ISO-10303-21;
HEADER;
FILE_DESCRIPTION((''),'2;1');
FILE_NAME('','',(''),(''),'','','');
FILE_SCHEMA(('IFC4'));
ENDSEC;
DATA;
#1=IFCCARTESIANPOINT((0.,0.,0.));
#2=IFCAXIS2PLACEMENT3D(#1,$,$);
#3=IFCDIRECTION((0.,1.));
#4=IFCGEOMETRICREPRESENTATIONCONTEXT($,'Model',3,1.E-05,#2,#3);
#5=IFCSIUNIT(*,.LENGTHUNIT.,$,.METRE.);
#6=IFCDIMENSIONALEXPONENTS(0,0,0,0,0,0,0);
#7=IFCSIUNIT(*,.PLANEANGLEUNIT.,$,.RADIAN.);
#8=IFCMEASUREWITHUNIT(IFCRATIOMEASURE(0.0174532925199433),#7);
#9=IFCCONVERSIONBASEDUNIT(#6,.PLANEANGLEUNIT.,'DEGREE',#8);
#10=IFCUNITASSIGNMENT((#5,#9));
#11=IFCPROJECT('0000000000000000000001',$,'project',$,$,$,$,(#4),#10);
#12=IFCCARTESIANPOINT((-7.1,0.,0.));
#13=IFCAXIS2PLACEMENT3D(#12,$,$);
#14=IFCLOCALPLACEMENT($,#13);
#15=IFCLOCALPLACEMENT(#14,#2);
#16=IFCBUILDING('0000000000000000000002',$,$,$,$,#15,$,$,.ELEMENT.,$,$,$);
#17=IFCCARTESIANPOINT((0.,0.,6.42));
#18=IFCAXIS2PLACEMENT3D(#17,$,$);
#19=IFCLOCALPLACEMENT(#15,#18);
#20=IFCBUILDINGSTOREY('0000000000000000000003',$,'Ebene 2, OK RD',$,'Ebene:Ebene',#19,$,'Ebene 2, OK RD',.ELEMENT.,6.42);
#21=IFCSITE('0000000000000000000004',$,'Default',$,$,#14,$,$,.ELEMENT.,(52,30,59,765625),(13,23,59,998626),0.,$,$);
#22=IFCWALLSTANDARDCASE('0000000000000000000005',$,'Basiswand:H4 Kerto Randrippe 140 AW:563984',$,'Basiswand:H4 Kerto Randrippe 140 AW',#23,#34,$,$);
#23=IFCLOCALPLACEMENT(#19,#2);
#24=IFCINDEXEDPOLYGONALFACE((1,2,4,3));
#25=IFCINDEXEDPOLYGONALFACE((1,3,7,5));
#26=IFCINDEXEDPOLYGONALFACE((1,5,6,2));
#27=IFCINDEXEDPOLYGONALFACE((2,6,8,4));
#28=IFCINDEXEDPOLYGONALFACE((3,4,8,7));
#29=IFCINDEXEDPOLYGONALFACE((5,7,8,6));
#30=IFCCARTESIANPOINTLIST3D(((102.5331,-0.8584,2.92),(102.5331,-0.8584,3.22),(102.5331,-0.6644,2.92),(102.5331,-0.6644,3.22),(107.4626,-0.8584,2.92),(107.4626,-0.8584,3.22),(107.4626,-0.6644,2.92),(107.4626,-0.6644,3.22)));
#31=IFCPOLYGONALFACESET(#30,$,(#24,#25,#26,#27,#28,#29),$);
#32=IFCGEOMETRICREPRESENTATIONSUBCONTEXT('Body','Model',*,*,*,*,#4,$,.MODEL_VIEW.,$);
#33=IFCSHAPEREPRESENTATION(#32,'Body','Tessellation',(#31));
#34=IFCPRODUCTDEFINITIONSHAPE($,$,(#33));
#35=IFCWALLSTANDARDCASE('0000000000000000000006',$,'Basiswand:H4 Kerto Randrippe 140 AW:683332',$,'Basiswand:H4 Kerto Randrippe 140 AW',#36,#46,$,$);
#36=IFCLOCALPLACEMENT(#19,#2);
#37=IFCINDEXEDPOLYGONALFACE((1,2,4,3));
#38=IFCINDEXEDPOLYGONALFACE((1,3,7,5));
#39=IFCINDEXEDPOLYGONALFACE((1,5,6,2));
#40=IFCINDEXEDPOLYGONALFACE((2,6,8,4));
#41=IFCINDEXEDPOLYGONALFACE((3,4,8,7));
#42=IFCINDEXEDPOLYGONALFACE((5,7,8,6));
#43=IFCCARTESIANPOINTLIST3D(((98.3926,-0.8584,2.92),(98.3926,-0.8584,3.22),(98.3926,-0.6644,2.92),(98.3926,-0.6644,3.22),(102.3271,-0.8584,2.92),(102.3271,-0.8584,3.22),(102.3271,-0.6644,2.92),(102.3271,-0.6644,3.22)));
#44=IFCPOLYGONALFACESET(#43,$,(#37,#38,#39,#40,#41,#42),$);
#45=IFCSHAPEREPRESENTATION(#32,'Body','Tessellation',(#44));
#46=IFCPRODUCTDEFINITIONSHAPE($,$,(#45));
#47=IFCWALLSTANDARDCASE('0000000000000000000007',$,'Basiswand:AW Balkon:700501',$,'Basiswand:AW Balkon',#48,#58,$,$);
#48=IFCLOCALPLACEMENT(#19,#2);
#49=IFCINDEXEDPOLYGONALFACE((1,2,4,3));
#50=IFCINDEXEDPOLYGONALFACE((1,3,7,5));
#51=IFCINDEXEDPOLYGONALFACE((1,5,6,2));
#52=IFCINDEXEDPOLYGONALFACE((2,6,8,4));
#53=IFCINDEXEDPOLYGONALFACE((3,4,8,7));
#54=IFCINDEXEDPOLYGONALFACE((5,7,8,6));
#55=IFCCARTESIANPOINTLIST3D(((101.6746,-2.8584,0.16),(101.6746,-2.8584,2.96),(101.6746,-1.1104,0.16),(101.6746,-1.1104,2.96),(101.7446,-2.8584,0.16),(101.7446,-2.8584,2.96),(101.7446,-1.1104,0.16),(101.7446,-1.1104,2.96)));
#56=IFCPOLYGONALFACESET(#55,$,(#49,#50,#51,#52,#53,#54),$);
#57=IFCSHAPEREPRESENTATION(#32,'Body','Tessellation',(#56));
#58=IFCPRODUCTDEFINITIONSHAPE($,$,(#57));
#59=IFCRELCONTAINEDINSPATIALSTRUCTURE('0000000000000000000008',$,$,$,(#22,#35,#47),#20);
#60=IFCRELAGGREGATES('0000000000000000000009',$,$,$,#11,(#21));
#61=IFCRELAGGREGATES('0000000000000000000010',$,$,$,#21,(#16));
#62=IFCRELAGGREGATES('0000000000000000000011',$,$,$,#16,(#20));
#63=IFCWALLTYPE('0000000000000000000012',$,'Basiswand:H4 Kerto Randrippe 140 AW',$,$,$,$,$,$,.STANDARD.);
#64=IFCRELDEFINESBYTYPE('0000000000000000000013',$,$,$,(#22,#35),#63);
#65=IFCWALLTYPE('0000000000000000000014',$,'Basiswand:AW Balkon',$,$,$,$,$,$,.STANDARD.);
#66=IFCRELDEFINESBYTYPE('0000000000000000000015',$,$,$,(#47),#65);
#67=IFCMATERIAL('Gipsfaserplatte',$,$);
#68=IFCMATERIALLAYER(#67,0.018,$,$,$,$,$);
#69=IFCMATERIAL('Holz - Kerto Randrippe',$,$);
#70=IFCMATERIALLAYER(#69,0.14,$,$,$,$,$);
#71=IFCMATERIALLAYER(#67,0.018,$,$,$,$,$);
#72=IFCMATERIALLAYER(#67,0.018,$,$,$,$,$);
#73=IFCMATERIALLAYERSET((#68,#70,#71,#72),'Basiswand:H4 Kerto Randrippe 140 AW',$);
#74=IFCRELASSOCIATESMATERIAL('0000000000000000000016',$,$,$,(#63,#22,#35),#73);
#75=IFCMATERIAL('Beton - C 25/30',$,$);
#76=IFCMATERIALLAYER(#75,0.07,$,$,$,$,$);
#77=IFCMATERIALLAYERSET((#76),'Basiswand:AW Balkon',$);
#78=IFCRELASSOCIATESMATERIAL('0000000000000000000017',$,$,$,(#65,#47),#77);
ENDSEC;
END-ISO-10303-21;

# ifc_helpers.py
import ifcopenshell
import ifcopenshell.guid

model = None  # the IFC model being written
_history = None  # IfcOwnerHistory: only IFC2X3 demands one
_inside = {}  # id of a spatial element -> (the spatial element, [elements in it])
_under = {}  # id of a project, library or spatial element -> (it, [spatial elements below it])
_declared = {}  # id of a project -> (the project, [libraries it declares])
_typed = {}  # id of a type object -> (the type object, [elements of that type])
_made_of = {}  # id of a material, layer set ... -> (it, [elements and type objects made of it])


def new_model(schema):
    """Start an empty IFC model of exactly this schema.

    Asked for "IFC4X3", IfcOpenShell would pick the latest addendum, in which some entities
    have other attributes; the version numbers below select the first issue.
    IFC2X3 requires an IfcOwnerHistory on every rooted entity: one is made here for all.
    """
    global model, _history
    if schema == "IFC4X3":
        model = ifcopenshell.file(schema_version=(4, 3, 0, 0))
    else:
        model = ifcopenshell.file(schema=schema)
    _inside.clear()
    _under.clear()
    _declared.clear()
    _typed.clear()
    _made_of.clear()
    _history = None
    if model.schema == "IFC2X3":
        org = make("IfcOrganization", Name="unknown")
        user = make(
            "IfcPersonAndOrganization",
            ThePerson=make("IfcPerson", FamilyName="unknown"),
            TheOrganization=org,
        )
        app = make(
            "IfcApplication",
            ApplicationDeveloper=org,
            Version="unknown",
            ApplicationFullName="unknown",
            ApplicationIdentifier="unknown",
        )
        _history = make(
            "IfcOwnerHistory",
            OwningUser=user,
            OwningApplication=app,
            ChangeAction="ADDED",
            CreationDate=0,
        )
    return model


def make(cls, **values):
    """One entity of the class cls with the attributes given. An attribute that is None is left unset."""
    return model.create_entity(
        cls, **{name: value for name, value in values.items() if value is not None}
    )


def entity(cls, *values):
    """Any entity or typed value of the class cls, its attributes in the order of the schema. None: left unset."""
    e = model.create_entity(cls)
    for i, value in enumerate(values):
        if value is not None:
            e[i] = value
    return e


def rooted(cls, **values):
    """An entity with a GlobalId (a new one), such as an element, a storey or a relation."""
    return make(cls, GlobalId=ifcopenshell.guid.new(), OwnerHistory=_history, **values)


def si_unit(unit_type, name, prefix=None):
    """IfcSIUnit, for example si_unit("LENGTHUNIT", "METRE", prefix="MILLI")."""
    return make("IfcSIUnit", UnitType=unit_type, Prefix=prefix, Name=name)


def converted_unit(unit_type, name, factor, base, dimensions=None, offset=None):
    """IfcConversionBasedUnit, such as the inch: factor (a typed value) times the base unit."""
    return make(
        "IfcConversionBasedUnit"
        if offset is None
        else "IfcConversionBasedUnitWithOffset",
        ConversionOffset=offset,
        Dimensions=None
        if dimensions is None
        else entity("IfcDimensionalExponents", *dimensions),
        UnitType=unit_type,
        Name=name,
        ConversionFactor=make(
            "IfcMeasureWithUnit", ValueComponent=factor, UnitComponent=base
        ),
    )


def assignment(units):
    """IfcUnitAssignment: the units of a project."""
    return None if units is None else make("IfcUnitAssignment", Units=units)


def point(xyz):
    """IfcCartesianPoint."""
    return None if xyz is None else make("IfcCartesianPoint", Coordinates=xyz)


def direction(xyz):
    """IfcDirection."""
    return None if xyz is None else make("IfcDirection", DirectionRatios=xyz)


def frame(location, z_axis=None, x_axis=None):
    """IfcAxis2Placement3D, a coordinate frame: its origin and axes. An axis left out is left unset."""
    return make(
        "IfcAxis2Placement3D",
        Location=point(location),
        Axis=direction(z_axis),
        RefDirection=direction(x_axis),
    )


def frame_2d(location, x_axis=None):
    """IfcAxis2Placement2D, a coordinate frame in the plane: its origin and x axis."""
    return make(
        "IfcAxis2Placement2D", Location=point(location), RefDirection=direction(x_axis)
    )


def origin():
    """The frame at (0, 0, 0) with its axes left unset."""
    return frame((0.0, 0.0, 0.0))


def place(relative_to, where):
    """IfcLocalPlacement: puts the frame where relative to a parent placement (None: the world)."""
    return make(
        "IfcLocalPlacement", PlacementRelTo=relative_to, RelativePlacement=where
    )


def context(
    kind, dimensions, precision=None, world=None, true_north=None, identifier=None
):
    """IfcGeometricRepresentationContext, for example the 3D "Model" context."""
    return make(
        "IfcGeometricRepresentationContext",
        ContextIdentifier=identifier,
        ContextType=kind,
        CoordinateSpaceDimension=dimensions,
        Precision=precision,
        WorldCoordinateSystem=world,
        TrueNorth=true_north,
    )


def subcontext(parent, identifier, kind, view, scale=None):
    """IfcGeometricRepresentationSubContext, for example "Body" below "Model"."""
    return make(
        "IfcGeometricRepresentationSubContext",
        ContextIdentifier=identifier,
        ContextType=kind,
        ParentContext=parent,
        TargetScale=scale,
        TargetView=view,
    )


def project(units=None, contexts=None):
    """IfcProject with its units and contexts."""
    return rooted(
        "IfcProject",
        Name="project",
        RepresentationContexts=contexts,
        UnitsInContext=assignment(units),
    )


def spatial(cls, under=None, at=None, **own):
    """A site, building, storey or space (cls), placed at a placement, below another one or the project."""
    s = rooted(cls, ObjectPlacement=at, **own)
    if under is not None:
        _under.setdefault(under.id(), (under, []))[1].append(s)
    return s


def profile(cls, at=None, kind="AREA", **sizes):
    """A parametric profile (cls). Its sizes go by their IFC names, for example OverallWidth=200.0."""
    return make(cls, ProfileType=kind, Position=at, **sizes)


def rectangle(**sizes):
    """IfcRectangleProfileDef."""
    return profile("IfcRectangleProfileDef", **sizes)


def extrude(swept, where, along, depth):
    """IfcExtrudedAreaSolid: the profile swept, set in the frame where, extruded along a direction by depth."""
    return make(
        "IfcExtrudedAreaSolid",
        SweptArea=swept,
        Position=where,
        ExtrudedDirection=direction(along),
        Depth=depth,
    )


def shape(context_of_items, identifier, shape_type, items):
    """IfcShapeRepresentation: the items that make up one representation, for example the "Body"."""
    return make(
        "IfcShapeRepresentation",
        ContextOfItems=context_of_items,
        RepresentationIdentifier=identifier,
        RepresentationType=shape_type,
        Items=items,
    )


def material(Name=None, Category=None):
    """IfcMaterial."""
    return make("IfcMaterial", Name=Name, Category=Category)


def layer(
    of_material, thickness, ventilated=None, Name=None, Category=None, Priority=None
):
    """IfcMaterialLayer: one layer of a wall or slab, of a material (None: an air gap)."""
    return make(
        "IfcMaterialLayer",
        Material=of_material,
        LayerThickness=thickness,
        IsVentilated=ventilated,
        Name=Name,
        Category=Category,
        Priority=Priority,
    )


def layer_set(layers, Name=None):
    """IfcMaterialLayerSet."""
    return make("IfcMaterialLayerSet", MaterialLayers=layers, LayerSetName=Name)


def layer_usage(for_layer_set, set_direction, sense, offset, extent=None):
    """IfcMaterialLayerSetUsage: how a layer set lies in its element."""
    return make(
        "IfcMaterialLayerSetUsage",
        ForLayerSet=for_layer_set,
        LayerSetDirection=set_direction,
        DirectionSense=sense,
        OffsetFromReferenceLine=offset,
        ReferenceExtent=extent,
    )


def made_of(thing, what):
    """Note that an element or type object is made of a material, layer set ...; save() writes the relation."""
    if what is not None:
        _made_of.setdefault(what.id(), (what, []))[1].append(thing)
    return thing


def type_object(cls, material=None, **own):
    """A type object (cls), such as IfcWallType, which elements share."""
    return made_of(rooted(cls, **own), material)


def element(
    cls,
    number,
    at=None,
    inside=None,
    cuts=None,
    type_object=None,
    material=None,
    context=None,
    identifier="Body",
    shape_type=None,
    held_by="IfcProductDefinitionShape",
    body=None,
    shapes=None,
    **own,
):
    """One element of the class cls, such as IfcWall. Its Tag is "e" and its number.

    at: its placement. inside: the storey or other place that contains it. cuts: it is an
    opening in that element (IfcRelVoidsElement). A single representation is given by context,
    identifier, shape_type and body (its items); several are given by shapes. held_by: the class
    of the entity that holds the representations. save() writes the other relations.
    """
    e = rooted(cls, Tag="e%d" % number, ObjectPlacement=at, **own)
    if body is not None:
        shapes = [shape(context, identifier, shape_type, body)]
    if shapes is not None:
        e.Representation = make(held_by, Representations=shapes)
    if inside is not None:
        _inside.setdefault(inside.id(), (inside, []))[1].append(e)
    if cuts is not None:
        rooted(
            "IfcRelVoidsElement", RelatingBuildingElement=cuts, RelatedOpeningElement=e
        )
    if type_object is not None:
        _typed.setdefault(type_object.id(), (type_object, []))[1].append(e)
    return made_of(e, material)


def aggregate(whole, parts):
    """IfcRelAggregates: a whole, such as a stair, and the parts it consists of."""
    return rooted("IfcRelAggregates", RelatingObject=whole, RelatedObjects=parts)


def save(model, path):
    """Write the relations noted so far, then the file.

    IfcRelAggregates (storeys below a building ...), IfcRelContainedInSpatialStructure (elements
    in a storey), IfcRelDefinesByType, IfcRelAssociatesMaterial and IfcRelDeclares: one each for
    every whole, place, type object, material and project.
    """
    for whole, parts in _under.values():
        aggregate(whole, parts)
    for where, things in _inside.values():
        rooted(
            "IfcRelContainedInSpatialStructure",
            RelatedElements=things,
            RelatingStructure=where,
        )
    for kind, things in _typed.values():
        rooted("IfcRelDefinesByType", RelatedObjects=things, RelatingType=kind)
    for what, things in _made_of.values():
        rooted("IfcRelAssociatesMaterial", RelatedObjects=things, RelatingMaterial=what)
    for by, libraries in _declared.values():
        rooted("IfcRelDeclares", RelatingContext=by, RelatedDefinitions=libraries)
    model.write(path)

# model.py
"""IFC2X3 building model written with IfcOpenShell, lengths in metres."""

from ifc_helpers import new_model, entity, si_unit, converted_unit, direction, frame, frame_2d, origin, place, context, subcontext, project, spatial, rectangle, extrude, material, layer, layer_set, layer_usage, type_object, element, save


model = new_model("IFC2X3")

# Units and contexts
model_context = context("Model", 3, precision=1e-05, world=origin(), true_north=direction((0.0, 1.0)))
body_context = subcontext(model_context, "Body", "Model", "MODEL_VIEW")
ifc_project = project(units=[si_unit("LENGTHUNIT", "METRE"), converted_unit("PLANEANGLEUNIT", "DEGREE", entity("IfcRatioMeasure", 0.0174532925199433), si_unit("PLANEANGLEUNIT", "RADIAN"), dimensions=[0, 0, 0, 0, 0, 0, 0])], contexts=[model_context])

# Site, building, storey
site_placement = place(None, frame((-7.1, 0.0, 0.0)))
site = spatial("IfcSite", under=ifc_project, at=site_placement, Name="Default", CompositionType="ELEMENT", RefLatitude=(52, 30, 59, 765625), RefLongitude=(13, 23, 59, 998626), RefElevation=0.0)
building_placement = place(site_placement, origin())
building = spatial("IfcBuilding", under=site, at=building_placement, CompositionType="ELEMENT")
storey_placement = place(building_placement, frame((0.0, 0.0, 6.42)))
storey = spatial("IfcBuildingStorey", under=building, at=storey_placement, Name="Ebene 2, OK RD", ObjectType="Ebene:Ebene", LongName="Ebene 2, OK RD", CompositionType="ELEMENT", Elevation=6.42)

# Shared definitions
ifc_material_1 = material(Name="Gipsfaserplatte")

# Walls
ifc_layer_1 = layer(ifc_material_1, 0.018)
ifc_material_2 = material(Name="Holz - Kerto Randrippe")
ifc_layer_2 = layer(ifc_material_2, 0.14)
ifc_layer_3 = layer(ifc_material_1, 0.018)
ifc_layer_4 = layer(ifc_material_1, 0.018)
ifc_layer_set_1 = layer_set([ifc_layer_1, ifc_layer_2, ifc_layer_3, ifc_layer_4], Name="Basiswand:H4 Kerto Randrippe 140 AW")
ifc_layer_usage_1 = layer_usage(ifc_layer_set_1, "AXIS2", "NEGATIVE", 0.097)
wall_type_1 = type_object("IfcWallType", Name="Basiswand:H4 Kerto Randrippe 140 AW", PredefinedType="STANDARD", material=ifc_layer_set_1)
wall_1_placement = place(storey_placement, frame((107.4626, -0.7614, 2.92), z_axis=(0.0, 0.0, 1.0), x_axis=(-1.0, 0.0, 0.0)))
element("IfcWallStandardCase", 1, at=wall_1_placement, inside=storey, type_object=wall_type_1, material=ifc_layer_usage_1, Name="Basiswand:H4 Kerto Randrippe 140 AW:563984", ObjectType="Basiswand:H4 Kerto Randrippe 140 AW", context=body_context, shape_type="SweptSolid", body=[
    extrude(rectangle(XDim=4.9295, YDim=0.194, at=frame_2d((2.4648, 0.0), x_axis=(-1.0, 0.0))), origin(), (0.0, 0.0, 1.0), 0.3),
])
ifc_layer_usage_2 = layer_usage(ifc_layer_set_1, "AXIS2", "NEGATIVE", 0.097)
wall_2_placement = place(storey_placement, frame((102.3271, -0.7614, 2.92), z_axis=(0.0, 0.0, 1.0), x_axis=(-1.0, 0.0, 0.0)))
element("IfcWallStandardCase", 2, at=wall_2_placement, inside=storey, type_object=wall_type_1, material=ifc_layer_usage_2, Name="Basiswand:H4 Kerto Randrippe 140 AW:683332", ObjectType="Basiswand:H4 Kerto Randrippe 140 AW", context=body_context, shape_type="SweptSolid", body=[
    extrude(rectangle(XDim=3.9345, YDim=0.194, at=frame_2d((1.9672, 0.0), x_axis=(-1.0, 0.0))), origin(), (0.0, 0.0, 1.0), 0.3),
])

# Wall
ifc_material_3 = material(Name="Beton - C 25/30")
ifc_layer_5 = layer(ifc_material_3, 0.07)
ifc_layer_set_2 = layer_set([ifc_layer_5], Name="Basiswand:AW Balkon")
ifc_layer_usage_3 = layer_usage(ifc_layer_set_2, "AXIS2", "NEGATIVE", 0.035)
wall_type_2 = type_object("IfcWallType", Name="Basiswand:AW Balkon", PredefinedType="STANDARD", material=ifc_layer_set_2)
wall_3_placement = place(storey_placement, frame((101.7096, -1.1104, 0.16), z_axis=(0.0, 0.0, 1.0), x_axis=(0.0, -1.0, 0.0)))
element("IfcWallStandardCase", 3, at=wall_3_placement, inside=storey, type_object=wall_type_2, material=ifc_layer_usage_3, Name="Basiswand:AW Balkon:700501", ObjectType="Basiswand:AW Balkon", context=body_context, shape_type="SweptSolid", body=[
    extrude(rectangle(XDim=1.748, YDim=0.07, at=frame_2d((0.874, 0.0), x_axis=(-1.0, 0.0))), origin(), (0.0, 0.0, 1.0), 2.8),
])

save(model, "model.ifc")
